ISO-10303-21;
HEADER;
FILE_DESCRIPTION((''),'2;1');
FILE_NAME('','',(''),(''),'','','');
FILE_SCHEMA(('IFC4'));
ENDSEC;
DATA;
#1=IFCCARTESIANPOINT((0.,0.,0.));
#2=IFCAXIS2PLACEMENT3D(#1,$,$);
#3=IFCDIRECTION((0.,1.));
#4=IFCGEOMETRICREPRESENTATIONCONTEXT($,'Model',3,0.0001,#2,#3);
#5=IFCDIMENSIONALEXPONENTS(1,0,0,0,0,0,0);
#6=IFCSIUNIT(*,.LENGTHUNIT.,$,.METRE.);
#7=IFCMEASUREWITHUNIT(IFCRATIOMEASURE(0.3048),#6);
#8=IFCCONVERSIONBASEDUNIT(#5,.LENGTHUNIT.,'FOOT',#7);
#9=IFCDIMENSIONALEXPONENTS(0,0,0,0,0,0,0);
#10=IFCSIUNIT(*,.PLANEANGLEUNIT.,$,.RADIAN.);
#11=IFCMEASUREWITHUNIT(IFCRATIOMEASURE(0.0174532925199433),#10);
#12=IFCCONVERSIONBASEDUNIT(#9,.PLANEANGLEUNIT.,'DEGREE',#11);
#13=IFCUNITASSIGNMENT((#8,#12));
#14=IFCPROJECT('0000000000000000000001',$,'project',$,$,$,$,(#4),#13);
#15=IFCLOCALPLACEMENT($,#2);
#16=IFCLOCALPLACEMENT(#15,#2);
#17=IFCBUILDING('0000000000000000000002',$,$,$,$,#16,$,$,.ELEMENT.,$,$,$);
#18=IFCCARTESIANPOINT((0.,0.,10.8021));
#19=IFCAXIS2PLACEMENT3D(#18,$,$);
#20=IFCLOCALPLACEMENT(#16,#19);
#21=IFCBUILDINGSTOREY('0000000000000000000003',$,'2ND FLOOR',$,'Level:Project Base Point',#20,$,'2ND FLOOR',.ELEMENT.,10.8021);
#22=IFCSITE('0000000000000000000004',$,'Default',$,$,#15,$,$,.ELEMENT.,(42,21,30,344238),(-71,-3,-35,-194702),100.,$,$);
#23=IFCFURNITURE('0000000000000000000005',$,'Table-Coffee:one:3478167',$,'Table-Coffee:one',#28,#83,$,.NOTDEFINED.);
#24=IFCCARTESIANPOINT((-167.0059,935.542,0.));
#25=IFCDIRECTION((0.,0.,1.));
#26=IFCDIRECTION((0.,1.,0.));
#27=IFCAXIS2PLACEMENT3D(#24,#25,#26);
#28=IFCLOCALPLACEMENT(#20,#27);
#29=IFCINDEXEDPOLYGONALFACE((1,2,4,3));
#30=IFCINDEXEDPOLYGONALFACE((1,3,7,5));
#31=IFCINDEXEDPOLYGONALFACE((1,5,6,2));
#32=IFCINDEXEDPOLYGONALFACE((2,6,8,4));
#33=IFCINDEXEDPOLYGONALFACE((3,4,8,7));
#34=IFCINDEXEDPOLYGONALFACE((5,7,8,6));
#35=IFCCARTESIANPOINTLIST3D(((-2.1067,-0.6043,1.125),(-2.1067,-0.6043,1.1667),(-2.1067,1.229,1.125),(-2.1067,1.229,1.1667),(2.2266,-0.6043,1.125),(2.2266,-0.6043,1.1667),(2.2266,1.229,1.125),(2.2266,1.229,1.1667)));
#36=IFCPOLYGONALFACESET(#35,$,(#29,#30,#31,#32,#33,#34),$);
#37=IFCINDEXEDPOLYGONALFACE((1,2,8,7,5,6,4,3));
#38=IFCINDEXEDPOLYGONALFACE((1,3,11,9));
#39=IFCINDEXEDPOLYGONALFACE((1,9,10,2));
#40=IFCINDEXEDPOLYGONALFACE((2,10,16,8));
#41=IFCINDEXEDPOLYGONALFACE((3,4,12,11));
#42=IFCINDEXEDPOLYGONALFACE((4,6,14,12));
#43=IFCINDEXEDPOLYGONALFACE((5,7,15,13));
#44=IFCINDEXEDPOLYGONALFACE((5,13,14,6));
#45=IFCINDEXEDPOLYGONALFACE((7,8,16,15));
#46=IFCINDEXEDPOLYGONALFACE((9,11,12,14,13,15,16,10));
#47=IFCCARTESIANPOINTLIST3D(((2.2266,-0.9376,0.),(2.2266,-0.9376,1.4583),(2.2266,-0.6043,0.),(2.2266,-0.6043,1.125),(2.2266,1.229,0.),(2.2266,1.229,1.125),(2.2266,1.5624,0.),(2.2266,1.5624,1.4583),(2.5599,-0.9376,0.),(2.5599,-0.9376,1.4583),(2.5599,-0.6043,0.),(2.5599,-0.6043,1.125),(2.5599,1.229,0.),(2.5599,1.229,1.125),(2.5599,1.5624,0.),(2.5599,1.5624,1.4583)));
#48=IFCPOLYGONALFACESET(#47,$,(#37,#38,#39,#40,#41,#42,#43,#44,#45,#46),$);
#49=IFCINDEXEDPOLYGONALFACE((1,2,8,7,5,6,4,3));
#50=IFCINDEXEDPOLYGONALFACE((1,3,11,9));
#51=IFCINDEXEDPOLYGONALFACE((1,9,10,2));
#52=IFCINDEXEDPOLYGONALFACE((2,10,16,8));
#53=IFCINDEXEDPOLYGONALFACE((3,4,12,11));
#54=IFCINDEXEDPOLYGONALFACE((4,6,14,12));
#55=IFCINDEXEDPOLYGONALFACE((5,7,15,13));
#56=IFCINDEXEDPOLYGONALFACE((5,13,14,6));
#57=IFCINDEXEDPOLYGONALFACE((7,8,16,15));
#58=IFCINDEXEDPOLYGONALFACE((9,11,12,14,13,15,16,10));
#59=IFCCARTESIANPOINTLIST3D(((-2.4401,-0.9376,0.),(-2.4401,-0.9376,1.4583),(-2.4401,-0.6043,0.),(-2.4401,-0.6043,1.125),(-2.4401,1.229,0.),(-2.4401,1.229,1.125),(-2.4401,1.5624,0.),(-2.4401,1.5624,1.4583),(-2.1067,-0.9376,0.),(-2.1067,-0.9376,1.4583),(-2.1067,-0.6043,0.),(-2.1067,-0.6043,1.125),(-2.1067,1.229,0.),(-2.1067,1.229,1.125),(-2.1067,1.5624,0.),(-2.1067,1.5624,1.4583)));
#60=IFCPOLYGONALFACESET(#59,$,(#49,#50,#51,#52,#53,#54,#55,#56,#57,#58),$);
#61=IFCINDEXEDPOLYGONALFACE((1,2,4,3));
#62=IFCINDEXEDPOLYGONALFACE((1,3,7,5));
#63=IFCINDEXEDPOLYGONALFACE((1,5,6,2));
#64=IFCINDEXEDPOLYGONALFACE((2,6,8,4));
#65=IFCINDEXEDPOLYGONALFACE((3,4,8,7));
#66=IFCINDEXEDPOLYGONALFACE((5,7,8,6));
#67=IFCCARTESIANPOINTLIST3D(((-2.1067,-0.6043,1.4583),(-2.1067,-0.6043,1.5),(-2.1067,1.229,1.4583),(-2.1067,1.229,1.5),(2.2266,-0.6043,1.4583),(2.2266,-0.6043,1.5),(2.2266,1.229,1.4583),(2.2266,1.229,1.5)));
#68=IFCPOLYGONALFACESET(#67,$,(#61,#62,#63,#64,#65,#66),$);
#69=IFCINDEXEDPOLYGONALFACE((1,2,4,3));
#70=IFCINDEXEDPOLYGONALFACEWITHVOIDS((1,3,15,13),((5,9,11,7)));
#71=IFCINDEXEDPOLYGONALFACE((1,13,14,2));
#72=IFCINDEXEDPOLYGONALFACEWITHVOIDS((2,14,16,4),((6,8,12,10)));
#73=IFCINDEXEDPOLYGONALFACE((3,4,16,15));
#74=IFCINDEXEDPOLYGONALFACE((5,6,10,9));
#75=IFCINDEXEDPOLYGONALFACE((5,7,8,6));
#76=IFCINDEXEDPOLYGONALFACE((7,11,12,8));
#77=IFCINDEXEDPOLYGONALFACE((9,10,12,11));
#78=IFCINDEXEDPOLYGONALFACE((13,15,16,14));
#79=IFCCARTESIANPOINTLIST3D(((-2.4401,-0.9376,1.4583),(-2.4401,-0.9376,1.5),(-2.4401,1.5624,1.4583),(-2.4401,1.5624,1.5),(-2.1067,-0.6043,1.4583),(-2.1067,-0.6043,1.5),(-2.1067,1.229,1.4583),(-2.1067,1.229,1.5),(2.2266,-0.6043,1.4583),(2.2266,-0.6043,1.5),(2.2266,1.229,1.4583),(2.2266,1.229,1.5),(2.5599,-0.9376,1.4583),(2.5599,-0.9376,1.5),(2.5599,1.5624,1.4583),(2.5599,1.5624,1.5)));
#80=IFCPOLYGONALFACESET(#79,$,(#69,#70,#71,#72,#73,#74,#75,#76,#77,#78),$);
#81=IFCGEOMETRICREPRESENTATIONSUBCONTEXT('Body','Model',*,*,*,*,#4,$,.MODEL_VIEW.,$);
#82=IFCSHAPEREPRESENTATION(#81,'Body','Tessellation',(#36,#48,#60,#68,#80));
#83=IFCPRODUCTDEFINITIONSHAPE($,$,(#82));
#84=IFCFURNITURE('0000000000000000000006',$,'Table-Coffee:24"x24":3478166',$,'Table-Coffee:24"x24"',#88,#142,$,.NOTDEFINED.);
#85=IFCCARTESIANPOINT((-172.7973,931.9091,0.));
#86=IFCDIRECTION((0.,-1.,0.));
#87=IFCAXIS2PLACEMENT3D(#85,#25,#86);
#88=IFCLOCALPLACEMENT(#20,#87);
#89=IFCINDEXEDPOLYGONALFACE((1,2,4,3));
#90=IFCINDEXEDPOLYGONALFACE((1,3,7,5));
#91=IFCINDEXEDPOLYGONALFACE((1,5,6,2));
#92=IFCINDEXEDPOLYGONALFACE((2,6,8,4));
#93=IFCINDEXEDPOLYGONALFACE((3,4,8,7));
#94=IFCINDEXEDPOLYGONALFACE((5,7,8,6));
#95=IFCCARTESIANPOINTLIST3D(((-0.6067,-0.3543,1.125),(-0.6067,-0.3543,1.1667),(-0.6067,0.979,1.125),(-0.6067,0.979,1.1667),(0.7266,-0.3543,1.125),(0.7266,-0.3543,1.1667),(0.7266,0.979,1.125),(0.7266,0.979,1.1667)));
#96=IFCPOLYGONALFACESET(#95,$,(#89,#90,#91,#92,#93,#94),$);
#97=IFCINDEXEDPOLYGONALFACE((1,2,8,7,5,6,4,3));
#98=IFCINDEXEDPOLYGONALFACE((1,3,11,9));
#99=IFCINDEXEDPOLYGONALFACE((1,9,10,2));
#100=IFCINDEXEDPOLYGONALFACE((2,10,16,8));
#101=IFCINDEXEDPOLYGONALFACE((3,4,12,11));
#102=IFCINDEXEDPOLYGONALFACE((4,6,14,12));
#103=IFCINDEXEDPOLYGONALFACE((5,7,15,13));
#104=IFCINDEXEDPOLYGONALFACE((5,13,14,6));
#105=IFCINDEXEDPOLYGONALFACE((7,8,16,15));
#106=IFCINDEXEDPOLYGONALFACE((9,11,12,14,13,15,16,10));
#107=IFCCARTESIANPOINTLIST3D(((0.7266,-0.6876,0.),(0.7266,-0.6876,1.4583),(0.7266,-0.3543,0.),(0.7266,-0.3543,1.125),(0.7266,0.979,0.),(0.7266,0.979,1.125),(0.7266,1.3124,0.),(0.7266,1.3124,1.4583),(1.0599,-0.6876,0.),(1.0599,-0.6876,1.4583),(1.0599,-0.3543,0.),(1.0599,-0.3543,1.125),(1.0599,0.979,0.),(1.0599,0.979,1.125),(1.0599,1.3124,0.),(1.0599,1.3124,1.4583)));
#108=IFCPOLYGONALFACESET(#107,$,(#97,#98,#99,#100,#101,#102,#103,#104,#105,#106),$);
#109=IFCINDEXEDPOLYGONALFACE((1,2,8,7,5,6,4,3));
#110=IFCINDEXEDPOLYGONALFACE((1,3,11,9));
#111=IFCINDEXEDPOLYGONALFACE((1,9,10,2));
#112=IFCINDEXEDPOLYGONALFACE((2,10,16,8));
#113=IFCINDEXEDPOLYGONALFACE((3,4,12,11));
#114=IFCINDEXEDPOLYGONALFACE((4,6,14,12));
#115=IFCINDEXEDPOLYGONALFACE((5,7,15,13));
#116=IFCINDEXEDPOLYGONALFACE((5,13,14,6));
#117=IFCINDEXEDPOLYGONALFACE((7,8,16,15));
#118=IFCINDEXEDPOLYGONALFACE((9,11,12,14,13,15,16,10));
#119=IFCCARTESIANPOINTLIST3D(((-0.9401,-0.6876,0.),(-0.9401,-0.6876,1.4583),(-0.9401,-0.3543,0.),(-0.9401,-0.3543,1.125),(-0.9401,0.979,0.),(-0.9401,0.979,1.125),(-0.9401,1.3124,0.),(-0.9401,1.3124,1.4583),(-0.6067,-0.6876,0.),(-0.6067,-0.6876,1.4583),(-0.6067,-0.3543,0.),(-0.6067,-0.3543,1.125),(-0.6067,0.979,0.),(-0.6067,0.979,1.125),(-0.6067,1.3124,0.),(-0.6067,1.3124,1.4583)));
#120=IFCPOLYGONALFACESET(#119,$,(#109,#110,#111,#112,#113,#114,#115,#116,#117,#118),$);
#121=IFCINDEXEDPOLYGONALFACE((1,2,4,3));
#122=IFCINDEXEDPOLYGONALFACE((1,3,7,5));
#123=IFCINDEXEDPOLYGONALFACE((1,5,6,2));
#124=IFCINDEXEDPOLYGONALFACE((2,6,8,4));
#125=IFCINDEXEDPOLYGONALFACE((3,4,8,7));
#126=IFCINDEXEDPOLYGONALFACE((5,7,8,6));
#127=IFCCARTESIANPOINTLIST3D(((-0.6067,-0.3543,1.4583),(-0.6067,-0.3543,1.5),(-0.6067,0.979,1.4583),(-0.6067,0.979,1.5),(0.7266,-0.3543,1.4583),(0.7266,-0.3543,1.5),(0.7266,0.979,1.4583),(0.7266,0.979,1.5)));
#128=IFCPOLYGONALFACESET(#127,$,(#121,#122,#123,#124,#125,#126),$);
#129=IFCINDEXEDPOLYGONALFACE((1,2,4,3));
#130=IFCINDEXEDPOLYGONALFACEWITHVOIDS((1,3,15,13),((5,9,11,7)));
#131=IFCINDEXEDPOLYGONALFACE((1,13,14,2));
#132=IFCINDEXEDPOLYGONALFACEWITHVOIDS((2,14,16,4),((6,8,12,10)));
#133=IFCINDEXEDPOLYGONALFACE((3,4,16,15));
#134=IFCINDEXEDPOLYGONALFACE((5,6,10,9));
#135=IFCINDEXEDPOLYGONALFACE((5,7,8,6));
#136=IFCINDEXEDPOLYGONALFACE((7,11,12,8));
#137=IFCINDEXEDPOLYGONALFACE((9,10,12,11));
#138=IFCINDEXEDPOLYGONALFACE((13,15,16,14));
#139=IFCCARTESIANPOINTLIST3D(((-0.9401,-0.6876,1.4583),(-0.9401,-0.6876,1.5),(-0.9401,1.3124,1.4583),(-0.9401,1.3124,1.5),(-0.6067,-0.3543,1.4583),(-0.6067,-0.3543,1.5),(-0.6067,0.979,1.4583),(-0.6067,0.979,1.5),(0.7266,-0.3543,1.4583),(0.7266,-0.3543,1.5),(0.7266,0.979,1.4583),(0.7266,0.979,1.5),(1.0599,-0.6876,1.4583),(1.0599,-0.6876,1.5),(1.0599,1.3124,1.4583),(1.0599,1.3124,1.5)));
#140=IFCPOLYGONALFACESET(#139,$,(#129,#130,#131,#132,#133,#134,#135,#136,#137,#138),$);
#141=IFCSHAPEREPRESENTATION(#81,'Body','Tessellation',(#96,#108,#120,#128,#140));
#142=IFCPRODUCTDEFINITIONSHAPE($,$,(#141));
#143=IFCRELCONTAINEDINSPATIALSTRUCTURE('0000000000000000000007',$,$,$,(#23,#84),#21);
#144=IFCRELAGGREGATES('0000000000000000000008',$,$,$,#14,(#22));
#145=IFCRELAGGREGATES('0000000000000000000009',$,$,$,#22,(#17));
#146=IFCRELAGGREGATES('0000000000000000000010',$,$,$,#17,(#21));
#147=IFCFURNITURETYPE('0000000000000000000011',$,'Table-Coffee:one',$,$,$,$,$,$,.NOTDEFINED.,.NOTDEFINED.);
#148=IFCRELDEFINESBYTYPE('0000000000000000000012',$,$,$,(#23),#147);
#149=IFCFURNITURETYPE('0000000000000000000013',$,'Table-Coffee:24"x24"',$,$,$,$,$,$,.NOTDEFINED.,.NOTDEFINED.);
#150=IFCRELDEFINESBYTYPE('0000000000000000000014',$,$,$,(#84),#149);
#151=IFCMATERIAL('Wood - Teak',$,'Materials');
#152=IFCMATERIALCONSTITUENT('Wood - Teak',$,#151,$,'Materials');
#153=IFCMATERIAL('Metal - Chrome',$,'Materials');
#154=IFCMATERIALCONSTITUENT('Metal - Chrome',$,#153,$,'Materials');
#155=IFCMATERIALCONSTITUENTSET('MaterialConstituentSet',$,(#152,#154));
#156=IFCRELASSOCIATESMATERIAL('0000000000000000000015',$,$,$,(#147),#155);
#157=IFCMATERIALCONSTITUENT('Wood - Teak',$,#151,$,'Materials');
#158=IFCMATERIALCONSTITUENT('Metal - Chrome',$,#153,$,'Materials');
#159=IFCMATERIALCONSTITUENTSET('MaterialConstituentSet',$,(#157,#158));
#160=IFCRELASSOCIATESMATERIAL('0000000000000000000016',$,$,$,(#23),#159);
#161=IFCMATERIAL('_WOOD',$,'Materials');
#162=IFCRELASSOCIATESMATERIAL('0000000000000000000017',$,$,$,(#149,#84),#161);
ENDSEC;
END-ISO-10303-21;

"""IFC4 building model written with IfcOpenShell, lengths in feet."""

from ifc_helpers import new_model, entity, si_unit, converted_unit, direction, frame, origin, origin_2d_with_axis, place, context, subcontext, project, spatial, polyline, rectangle, outline, extrude, source, transform, mapped, material, constituent, constituent_set, type_object, type_shapes, element, save


model = new_model("IFC4")

# Units and contexts
model_context = context("Model", 3, precision=0.0001, world=origin(), true_north=direction((0.0, 1.0)))
body_context = subcontext(model_context, "Body", "Model", "MODEL_VIEW")
ifc_project = project(units=[converted_unit("LENGTHUNIT", "FOOT", entity("IfcRatioMeasure", 0.3048), si_unit("LENGTHUNIT", "METRE"), dimensions=[1, 0, 0, 0, 0, 0, 0]), converted_unit("PLANEANGLEUNIT", "DEGREE", entity("IfcRatioMeasure", 0.0174532925199433), si_unit("PLANEANGLEUNIT", "RADIAN"), dimensions=[0, 0, 0, 0, 0, 0, 0])], contexts=[model_context])

# Site, building, storey
site_placement = place(None, origin())
site = spatial("IfcSite", under=ifc_project, at=site_placement, Name="Default", CompositionType="ELEMENT", RefLatitude=(42, 21, 30, 344238), RefLongitude=(-71, -3, -35, -194702), RefElevation=100.0)
building_placement = place(site_placement, origin())
building = spatial("IfcBuilding", under=site, at=building_placement, CompositionType="ELEMENT")
storey_placement = place(building_placement, frame((0.0, 0.0, 10.8021)))
storey = spatial("IfcBuildingStorey", under=building, at=storey_placement, Name="2ND FLOOR", ObjectType="Level:Project Base Point", LongName="2ND FLOOR", CompositionType="ELEMENT", Elevation=10.8021)

# Furniture
ifc_material_1 = material(Name="Wood - Teak", Category="Materials")
ifc_constituent_1 = constituent(ifc_material_1, Name="Wood - Teak", Category="Materials")
ifc_material_2 = material(Name="Metal - Chrome", Category="Materials")
ifc_constituent_2 = constituent(ifc_material_2, Name="Metal - Chrome", Category="Materials")
ifc_constituent_set_1 = constituent_set(constituents=[ifc_constituent_1, ifc_constituent_2], Name="MaterialConstituentSet")
ifc_constituent_3 = constituent(ifc_material_1, Name="Wood - Teak", Category="Materials")
ifc_constituent_4 = constituent(ifc_material_2, Name="Metal - Chrome", Category="Materials")
ifc_constituent_set_2 = constituent_set(constituents=[ifc_constituent_3, ifc_constituent_4], Name="MaterialConstituentSet")
furniture_type_1 = type_object("IfcFurnitureType", Name="Table-Coffee:one", AssemblyPlace="NOTDEFINED", PredefinedType="NOTDEFINED", material=ifc_constituent_set_2)
shared_shape_1 = source(origin(), body_context, "Body", "SweptSolid", [
    extrude(rectangle(XDim=4.3333, YDim=1.8333, at=origin_2d_with_axis()), frame((0.0599, 0.3124, 1.125), z_axis=(0.0, 0.0, 1.0), x_axis=(-1.0, 0.0, 0.0)), (0.0, 0.0, 1.0), 0.0417),
    extrude(outline(polyline([(-0.6458, -1.25), (0.8125, -1.25), (0.8125, 1.25), (-0.6458, 1.25), (-0.6458, 0.9167), (0.4792, 0.9167), (0.4792, -0.9167), (-0.6458, -0.9167), (-0.6458, -1.25)])), frame((2.2266, 0.3124, 0.6458), z_axis=(1.0, 0.0, 0.0), x_axis=(0.0, 0.0, 1.0)), (0.0, 0.0, 1.0), 0.3333),
    extrude(outline(polyline([(-1.25, -0.8125), (1.25, -0.8125), (1.25, 0.6458), (0.9167, 0.6458), (0.9167, -0.4792), (-0.9167, -0.4792), (-0.9167, 0.6458), (-1.25, 0.6458), (-1.25, -0.8125)])), frame((-2.4401, 0.3124, 0.6458), z_axis=(1.0, 0.0, 0.0), x_axis=(0.0, -1.0, 0.0)), (0.0, 0.0, 1.0), 0.3333),
    extrude(rectangle(XDim=4.3333, YDim=1.8333, at=origin_2d_with_axis()), frame((0.0599, 0.3124, 1.4583), z_axis=(0.0, 0.0, 1.0), x_axis=(-1.0, 0.0, 0.0)), (0.0, 0.0, 1.0), 0.0417),
    extrude(outline(polyline([(-2.5, -1.25), (2.5, -1.25), (2.5, 1.25), (-2.5, 1.25), (-2.5, -1.25)]), holes=[polyline([(-2.1667, -0.9167), (-2.1667, 0.9167), (2.1667, 0.9167), (2.1667, -0.9167), (-2.1667, -0.9167)])]), frame((0.0599, 0.3124, 1.4583), z_axis=(0.0, 0.0, 1.0), x_axis=(-1.0, 0.0, 0.0)), (0.0, 0.0, 1.0), 0.0417),
])
type_shapes(furniture_type_1, [shared_shape_1])
furniture_1_placement = place(storey_placement, frame((-167.0059, 935.542, 0.0), z_axis=(0.0, 0.0, 1.0), x_axis=(0.0, 1.0, 0.0)))
element("IfcFurniture", 1, at=furniture_1_placement, inside=storey, type_object=furniture_type_1, material=ifc_constituent_set_1, Name="Table-Coffee:one:3478167", ObjectType="Table-Coffee:one", PredefinedType="NOTDEFINED", context=body_context, shape_type="MappedRepresentation", body=[
    mapped(shared_shape_1, transform((0.0, 0.0, 0.0), scale=1.0)),
])
ifc_material_3 = material(Name="_WOOD", Category="Materials")
furniture_type_2 = type_object("IfcFurnitureType", Name="Table-Coffee:24\"x24\"", AssemblyPlace="NOTDEFINED", PredefinedType="NOTDEFINED", material=ifc_material_3)
shared_shape_2 = source(origin(), body_context, "Body", "SweptSolid", [
    extrude(rectangle(XDim=1.3333, YDim=1.3333, at=origin_2d_with_axis()), frame((0.0599, 0.3124, 1.125), z_axis=(0.0, 0.0, 1.0), x_axis=(-1.0, 0.0, 0.0)), (0.0, 0.0, 1.0), 0.0417),
    extrude(outline(polyline([(-0.6458, -1.0), (0.8125, -1.0), (0.8125, 1.0), (-0.6458, 1.0), (-0.6458, 0.6667), (0.4792, 0.6667), (0.4792, -0.6667), (-0.6458, -0.6667), (-0.6458, -1.0)])), frame((0.7266, 0.3124, 0.6458), z_axis=(1.0, 0.0, 0.0), x_axis=(0.0, 0.0, 1.0)), (0.0, 0.0, 1.0), 0.3333),
    extrude(outline(polyline([(-1.0, -0.8125), (1.0, -0.8125), (1.0, 0.6458), (0.6667, 0.6458), (0.6667, -0.4792), (-0.6667, -0.4792), (-0.6667, 0.6458), (-1.0, 0.6458), (-1.0, -0.8125)])), frame((-0.9401, 0.3124, 0.6458), z_axis=(1.0, 0.0, 0.0), x_axis=(0.0, -1.0, 0.0)), (0.0, 0.0, 1.0), 0.3333),
    extrude(rectangle(XDim=1.3333, YDim=1.3333, at=origin_2d_with_axis()), frame((0.0599, 0.3124, 1.4583), z_axis=(0.0, 0.0, 1.0), x_axis=(-1.0, 0.0, 0.0)), (0.0, 0.0, 1.0), 0.0417),
    extrude(outline(polyline([(-1.0, -1.0), (1.0, -1.0), (1.0, 1.0), (-1.0, 1.0), (-1.0, -1.0)]), holes=[polyline([(-0.6667, -0.6667), (-0.6667, 0.6667), (0.6667, 0.6667), (0.6667, -0.6667), (-0.6667, -0.6667)])]), frame((0.0599, 0.3124, 1.4583), z_axis=(0.0, 0.0, 1.0), x_axis=(-1.0, 0.0, 0.0)), (0.0, 0.0, 1.0), 0.0417),
])
type_shapes(furniture_type_2, [shared_shape_2])
furniture_2_placement = place(storey_placement, frame((-172.7973, 931.9091, 0.0), z_axis=(0.0, 0.0, 1.0), x_axis=(0.0, -1.0, 0.0)))
element("IfcFurniture", 2, at=furniture_2_placement, inside=storey, type_object=furniture_type_2, material=ifc_material_3, Name="Table-Coffee:24\"x24\":3478166", ObjectType="Table-Coffee:24\"x24\"", PredefinedType="NOTDEFINED", context=body_context, shape_type="MappedRepresentation", body=[
    mapped(shared_shape_2, transform((0.0, 0.0, 0.0), scale=1.0)),
])

save(model, "model.ifc")
